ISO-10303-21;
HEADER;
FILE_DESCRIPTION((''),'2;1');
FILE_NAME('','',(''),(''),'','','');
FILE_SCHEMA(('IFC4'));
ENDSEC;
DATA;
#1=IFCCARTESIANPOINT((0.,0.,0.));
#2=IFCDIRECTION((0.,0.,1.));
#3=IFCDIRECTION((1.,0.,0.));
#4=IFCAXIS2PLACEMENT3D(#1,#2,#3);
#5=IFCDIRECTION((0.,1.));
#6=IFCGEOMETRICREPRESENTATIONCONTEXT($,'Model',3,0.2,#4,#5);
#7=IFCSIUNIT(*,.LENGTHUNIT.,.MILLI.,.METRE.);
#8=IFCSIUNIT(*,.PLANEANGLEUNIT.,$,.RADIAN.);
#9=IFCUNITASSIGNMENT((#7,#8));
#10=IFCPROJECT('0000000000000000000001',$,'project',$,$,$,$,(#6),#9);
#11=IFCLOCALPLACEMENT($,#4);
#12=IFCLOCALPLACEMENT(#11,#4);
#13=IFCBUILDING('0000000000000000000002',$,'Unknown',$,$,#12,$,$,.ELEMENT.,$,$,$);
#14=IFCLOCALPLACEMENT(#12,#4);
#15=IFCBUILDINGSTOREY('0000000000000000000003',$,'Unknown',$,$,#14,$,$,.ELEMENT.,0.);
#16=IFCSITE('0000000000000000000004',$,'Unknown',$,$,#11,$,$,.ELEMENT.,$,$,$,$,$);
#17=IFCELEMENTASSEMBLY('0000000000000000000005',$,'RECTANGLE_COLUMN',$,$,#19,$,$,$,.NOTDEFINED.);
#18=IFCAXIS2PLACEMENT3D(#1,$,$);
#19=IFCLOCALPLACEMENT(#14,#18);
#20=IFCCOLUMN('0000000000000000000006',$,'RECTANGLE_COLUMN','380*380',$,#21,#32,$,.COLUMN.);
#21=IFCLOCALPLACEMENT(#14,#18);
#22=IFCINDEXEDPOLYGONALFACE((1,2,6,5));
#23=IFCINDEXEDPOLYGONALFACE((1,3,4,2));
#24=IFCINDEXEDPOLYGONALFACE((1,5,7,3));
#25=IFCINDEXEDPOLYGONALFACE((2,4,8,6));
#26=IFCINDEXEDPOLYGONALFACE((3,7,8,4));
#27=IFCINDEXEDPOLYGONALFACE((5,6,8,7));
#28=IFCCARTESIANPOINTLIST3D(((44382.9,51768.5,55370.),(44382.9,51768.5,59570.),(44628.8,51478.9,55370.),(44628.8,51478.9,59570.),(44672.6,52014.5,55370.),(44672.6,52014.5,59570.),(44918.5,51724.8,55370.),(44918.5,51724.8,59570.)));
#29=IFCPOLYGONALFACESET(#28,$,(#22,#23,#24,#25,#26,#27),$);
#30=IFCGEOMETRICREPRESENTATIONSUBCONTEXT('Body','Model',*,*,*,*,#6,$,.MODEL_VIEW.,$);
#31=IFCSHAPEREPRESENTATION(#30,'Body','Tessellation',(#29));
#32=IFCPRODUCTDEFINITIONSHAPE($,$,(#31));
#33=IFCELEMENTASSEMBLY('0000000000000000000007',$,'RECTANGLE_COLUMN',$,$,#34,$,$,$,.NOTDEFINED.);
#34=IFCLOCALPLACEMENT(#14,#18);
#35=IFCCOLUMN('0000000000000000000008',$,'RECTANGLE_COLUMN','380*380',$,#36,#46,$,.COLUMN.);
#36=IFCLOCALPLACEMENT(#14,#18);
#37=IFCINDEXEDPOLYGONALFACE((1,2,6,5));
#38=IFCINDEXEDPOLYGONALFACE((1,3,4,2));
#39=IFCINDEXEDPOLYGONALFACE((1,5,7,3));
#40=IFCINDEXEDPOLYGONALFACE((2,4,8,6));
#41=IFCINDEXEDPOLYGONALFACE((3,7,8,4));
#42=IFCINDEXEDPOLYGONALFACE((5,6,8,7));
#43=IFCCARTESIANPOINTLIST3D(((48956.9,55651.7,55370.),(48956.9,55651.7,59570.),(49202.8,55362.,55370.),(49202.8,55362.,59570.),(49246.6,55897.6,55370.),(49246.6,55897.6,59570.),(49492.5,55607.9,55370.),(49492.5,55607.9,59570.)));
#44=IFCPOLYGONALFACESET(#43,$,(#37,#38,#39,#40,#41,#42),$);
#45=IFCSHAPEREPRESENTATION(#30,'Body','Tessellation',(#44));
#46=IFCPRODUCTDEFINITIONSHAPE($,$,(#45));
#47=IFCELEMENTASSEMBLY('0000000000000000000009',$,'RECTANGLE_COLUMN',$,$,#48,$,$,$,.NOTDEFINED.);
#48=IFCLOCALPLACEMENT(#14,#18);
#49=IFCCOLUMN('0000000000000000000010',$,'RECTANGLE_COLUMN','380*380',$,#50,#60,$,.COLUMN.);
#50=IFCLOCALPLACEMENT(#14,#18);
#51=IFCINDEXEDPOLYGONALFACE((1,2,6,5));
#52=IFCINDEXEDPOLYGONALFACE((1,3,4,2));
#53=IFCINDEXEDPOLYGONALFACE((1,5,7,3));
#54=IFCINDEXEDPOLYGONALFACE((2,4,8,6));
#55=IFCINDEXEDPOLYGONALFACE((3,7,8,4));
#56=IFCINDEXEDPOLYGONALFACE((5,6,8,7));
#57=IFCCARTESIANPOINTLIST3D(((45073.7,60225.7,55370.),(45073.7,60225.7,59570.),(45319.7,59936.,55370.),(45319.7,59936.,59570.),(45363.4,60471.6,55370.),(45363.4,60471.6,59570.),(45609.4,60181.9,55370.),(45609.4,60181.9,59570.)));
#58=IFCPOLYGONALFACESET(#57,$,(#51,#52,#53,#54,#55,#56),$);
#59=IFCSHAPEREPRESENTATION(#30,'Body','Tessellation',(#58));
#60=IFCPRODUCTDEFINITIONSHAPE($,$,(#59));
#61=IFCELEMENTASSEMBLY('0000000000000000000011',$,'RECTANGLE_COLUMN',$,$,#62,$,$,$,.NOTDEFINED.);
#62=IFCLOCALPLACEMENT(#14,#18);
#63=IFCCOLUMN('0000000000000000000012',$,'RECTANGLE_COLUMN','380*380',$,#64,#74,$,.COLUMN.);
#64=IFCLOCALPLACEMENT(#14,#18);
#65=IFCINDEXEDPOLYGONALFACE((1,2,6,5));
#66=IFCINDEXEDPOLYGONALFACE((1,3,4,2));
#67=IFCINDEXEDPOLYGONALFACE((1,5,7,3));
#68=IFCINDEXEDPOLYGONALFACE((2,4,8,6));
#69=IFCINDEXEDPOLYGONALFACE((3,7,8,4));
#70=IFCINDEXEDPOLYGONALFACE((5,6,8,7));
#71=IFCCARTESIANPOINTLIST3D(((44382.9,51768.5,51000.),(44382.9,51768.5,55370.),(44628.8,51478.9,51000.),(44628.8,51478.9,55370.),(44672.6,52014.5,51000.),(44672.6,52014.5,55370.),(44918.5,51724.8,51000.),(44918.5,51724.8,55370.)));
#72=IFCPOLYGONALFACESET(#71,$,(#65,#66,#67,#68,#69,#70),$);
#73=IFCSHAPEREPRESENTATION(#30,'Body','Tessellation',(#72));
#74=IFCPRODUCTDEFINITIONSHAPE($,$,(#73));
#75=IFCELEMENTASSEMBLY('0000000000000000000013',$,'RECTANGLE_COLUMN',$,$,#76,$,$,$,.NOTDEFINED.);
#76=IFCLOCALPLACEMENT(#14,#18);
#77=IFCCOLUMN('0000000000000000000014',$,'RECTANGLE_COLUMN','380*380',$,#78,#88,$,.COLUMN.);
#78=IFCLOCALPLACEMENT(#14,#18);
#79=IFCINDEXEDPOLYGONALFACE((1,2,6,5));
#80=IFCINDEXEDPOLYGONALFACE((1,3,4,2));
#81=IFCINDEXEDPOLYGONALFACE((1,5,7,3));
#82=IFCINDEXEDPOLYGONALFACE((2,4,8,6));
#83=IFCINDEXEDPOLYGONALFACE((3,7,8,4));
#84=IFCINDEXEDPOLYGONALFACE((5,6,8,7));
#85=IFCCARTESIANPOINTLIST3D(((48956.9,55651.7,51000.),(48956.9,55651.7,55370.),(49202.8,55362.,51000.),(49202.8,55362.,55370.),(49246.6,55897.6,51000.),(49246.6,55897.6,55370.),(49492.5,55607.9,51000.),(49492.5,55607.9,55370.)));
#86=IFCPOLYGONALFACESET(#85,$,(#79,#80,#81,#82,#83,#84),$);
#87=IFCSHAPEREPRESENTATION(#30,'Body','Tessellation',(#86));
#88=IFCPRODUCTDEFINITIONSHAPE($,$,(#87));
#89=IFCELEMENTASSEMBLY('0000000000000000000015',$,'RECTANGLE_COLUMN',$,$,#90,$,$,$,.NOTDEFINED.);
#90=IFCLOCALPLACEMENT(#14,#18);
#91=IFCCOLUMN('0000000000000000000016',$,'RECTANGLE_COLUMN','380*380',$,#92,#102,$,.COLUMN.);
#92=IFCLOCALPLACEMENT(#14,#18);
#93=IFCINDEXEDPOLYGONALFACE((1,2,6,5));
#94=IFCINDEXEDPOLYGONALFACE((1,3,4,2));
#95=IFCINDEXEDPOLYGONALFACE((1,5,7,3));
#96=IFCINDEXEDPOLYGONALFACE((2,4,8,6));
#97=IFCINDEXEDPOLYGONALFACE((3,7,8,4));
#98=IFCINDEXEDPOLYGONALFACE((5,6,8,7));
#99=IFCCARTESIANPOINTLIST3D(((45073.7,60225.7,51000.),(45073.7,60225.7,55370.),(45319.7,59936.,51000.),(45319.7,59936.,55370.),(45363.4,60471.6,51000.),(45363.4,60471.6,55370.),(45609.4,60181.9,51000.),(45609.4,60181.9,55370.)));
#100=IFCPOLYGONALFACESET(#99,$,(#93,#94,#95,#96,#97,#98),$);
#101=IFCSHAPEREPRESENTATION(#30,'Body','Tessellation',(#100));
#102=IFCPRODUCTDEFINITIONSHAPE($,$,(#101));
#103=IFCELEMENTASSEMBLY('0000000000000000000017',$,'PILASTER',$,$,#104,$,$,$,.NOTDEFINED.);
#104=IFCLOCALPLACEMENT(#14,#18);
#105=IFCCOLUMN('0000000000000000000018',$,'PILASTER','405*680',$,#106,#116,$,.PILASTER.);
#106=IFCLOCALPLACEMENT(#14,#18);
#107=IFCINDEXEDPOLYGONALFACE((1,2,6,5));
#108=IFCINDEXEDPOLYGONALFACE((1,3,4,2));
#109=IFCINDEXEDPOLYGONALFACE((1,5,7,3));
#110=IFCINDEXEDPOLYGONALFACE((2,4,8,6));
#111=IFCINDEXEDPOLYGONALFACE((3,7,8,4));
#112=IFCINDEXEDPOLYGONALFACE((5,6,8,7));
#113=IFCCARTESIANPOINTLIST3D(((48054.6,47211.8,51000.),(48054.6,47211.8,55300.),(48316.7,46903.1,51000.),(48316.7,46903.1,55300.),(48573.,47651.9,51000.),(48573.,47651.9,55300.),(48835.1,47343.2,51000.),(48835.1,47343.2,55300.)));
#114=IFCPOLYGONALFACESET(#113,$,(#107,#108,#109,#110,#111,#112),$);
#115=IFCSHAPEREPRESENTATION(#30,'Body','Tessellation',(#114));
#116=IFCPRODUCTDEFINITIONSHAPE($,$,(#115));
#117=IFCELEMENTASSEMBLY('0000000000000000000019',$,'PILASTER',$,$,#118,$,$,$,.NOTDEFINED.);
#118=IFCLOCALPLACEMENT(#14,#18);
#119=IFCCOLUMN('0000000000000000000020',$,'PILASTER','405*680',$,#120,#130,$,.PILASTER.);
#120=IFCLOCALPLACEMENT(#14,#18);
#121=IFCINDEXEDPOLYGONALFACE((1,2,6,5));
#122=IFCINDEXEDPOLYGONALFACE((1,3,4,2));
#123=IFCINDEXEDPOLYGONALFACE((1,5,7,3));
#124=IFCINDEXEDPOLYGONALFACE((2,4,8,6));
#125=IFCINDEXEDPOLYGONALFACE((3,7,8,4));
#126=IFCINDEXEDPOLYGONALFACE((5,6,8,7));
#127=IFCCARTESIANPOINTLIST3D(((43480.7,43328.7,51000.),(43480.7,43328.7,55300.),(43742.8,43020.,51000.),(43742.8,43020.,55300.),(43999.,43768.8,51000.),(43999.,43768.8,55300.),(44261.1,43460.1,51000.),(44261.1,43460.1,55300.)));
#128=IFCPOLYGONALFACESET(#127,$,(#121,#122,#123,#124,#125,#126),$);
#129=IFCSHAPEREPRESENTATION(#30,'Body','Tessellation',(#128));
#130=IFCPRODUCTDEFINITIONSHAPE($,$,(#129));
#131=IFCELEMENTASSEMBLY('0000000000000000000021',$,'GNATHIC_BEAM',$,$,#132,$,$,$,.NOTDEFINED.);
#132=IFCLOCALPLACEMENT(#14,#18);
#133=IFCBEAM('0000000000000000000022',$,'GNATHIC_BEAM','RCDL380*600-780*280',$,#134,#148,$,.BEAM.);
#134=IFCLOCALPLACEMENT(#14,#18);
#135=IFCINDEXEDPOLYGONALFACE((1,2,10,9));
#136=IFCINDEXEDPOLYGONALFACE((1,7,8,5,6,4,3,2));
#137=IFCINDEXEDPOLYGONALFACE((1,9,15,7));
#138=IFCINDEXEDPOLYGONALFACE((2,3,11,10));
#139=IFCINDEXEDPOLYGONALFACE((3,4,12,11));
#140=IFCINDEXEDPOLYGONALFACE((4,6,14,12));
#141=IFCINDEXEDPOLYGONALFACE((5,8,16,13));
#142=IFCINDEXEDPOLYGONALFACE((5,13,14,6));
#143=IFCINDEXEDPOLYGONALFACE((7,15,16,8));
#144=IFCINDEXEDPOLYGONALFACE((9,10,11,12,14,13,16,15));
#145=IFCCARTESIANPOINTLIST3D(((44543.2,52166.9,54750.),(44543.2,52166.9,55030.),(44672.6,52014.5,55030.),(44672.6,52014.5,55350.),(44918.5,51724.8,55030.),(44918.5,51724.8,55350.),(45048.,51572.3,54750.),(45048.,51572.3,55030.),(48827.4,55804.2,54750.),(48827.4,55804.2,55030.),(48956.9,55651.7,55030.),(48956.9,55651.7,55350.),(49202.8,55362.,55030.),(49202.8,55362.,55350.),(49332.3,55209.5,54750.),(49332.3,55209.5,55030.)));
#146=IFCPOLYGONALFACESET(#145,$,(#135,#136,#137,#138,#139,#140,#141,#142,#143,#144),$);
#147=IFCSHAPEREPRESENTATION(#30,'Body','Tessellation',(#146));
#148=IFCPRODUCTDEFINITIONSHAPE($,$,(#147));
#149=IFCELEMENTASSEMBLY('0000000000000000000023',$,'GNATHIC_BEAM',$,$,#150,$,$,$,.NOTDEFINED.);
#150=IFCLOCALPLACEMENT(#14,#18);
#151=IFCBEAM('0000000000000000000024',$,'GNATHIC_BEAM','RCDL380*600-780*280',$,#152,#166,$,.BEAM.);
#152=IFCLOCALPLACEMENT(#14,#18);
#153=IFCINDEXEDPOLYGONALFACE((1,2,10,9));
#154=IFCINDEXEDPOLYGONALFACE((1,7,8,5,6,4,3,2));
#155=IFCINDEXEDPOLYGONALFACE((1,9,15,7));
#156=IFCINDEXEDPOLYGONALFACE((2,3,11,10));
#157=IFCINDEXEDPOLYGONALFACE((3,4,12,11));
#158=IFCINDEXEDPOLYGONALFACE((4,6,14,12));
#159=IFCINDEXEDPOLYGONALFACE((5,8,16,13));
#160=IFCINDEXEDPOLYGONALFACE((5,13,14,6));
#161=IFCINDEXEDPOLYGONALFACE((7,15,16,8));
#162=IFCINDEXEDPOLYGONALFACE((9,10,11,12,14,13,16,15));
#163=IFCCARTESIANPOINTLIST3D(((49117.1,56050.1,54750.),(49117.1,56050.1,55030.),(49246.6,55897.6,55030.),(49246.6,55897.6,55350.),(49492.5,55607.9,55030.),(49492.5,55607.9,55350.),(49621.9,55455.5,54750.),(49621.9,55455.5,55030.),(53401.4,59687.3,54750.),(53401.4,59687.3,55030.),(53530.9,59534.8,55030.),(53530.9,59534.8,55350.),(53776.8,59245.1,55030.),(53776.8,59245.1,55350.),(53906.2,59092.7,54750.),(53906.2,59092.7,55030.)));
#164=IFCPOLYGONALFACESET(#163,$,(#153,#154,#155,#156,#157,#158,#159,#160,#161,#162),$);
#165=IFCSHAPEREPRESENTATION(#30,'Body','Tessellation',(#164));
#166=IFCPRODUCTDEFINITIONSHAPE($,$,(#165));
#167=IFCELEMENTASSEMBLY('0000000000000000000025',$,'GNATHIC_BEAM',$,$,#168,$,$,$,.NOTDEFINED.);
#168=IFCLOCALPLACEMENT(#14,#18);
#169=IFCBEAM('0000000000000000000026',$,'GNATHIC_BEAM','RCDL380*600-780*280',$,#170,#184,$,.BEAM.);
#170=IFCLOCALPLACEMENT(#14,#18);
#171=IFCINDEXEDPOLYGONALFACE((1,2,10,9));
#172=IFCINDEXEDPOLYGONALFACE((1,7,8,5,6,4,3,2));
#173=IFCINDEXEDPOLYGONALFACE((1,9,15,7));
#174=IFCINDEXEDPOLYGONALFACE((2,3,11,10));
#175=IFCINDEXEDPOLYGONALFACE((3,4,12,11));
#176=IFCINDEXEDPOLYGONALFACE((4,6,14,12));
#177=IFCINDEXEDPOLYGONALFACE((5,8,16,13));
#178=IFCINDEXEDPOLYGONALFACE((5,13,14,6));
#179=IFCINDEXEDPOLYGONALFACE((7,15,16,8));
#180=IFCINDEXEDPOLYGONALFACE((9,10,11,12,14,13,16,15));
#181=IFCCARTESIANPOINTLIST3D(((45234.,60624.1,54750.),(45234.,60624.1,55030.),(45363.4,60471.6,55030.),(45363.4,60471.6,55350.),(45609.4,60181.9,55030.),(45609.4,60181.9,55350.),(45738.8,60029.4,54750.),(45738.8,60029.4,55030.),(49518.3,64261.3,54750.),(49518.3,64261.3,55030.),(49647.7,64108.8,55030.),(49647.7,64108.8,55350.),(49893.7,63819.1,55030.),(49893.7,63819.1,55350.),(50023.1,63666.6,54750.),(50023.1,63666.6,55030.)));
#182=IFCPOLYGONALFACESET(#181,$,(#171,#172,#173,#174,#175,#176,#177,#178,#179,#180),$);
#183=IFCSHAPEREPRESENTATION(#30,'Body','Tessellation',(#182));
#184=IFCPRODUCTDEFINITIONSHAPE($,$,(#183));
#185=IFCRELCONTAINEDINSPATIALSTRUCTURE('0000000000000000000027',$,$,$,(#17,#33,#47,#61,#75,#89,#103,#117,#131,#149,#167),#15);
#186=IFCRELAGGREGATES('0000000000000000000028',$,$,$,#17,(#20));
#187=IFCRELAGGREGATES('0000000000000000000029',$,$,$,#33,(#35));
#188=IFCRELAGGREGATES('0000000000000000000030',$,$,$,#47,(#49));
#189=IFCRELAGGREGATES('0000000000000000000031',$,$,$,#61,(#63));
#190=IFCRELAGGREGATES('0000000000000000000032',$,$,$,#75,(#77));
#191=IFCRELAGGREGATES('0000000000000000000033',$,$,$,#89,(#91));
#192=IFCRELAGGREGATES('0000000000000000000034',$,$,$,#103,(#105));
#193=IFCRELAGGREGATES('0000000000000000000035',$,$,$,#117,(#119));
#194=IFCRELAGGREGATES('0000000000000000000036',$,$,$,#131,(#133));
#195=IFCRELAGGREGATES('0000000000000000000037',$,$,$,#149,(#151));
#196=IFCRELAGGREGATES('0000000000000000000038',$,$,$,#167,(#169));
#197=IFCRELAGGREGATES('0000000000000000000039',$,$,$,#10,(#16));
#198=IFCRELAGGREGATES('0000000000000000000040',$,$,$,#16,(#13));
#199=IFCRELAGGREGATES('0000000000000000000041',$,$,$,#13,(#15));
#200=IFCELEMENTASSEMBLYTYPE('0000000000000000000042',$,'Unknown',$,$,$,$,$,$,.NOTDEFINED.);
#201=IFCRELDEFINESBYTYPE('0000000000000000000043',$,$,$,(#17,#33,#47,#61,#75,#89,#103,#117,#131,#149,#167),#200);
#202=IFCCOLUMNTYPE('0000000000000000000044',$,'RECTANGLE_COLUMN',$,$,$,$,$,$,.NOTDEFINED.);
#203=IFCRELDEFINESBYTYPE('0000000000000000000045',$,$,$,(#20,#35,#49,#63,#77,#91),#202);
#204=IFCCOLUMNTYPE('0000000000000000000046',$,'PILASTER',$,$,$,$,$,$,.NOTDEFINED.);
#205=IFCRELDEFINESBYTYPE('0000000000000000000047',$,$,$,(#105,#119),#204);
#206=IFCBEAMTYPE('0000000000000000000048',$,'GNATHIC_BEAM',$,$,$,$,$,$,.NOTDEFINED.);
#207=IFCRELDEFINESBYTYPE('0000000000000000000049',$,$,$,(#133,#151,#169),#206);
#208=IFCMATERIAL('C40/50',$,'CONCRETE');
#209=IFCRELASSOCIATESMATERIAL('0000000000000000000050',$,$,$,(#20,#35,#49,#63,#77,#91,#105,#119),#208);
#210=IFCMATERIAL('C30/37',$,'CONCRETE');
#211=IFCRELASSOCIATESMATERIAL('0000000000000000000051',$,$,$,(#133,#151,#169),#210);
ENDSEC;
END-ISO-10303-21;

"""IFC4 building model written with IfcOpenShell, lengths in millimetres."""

from ifc_helpers import new_model, si_unit, direction, frame, origin_with_axes, origin_2d_with_axis, place, context, subcontext, project, spatial, polyline, rectangle, outline, extrude, material, material_profile, profile_set, profile_usage, type_object, element, aggregate, save


model = new_model("IFC4")

# Units and contexts
model_context = context("Model", 3, precision=0.2, world=origin_with_axes(), true_north=direction((0.0, 1.0)))
body_context = subcontext(model_context, "Body", "Model", "MODEL_VIEW")
ifc_project = project(units=[si_unit("LENGTHUNIT", "METRE", prefix="MILLI"), si_unit("PLANEANGLEUNIT", "RADIAN")], contexts=[model_context])

# Site, building, storey
site_placement = place(None, origin_with_axes())
site = spatial("IfcSite", under=ifc_project, at=site_placement, Name="Unknown", CompositionType="ELEMENT")
building_placement = place(site_placement, origin_with_axes())
building = spatial("IfcBuilding", under=site, at=building_placement, Name="Unknown", CompositionType="ELEMENT")
storey_placement = place(building_placement, origin_with_axes())
storey = spatial("IfcBuildingStorey", under=building, at=storey_placement, Name="Unknown", CompositionType="ELEMENT", Elevation=0.0)

# Shared definitions
element_assembly_type = type_object("IfcElementAssemblyType", Name="Unknown", PredefinedType="NOTDEFINED")
ifc_material_1 = material(Name="C40/50", Category="CONCRETE")

# Element assemblies, columns
ifc_material_profile_1 = material_profile(ifc_material_1, rectangle(XDim=380.0, YDim=380.0, at=origin_2d_with_axis()), Name="380*380")
ifc_profile_set_1 = profile_set([ifc_material_profile_1])
ifc_profile_usage_1 = profile_usage(ifc_profile_set_1, cardinal=5)
column_type_1 = type_object("IfcColumnType", Name="RECTANGLE_COLUMN")
assembly_1_placement = place(storey_placement, frame((44650.7, 51746.7, 55370.0), z_axis=(-0.762329, -0.64719, 0.0), x_axis=(0.0, 0.0, 1.0)))
assembly_1 = element("IfcElementAssembly", 1, at=assembly_1_placement, inside=storey, type_object=element_assembly_type, Name="RECTANGLE_COLUMN", PredefinedType="NOTDEFINED")
column_1_placement = place(assembly_1_placement, origin_with_axes())
column_1 = element("IfcColumn", 2, at=column_1_placement, type_object=column_type_1, material=ifc_profile_usage_1, Name="RECTANGLE_COLUMN", Description="380*380", PredefinedType="COLUMN", context=body_context, shape_type="SolidModel", body=[
    extrude(rectangle(XDim=380.0, YDim=380.0, at=origin_2d_with_axis()), frame((0.0, 0.0, 0.0), z_axis=(-1.0, 0.0, 0.0), x_axis=(0.0, 0.0, 1.0)), (0.0, 0.0, -1.0), 4200.0),
])
aggregate(assembly_1, [column_1])
assembly_2_placement = place(storey_placement, frame((49224.7, 55629.8, 55370.0), z_axis=(-0.762329, -0.64719, 0.0), x_axis=(0.0, 0.0, 1.0)))
assembly_2 = element("IfcElementAssembly", 3, at=assembly_2_placement, inside=storey, type_object=element_assembly_type, Name="RECTANGLE_COLUMN", PredefinedType="NOTDEFINED")
column_2_placement = place(assembly_2_placement, origin_with_axes())
column_2 = element("IfcColumn", 4, at=column_2_placement, type_object=column_type_1, material=ifc_profile_usage_1, Name="RECTANGLE_COLUMN", Description="380*380", PredefinedType="COLUMN", context=body_context, shape_type="SolidModel", body=[
    extrude(rectangle(XDim=380.0, YDim=380.0, at=origin_2d_with_axis()), frame((0.0, 0.0, 0.0), z_axis=(-1.0, 0.0, 0.0), x_axis=(0.0, 0.0, 1.0)), (0.0, 0.0, -1.0), 4200.0),
])
aggregate(assembly_2, [column_2])
assembly_3_placement = place(storey_placement, frame((45341.6, 60203.8, 55370.0), z_axis=(-0.762329, -0.64719, 0.0), x_axis=(0.0, 0.0, 1.0)))
assembly_3 = element("IfcElementAssembly", 5, at=assembly_3_placement, inside=storey, type_object=element_assembly_type, Name="RECTANGLE_COLUMN", PredefinedType="NOTDEFINED")
column_3_placement = place(assembly_3_placement, origin_with_axes())
column_3 = element("IfcColumn", 6, at=column_3_placement, type_object=column_type_1, material=ifc_profile_usage_1, Name="RECTANGLE_COLUMN", Description="380*380", PredefinedType="COLUMN", context=body_context, shape_type="SolidModel", body=[
    extrude(rectangle(XDim=380.0, YDim=380.0, at=origin_2d_with_axis()), frame((0.0, 0.0, 0.0), z_axis=(-1.0, 0.0, 0.0), x_axis=(0.0, 0.0, 1.0)), (0.0, 0.0, -1.0), 4200.0),
])
aggregate(assembly_3, [column_3])
assembly_4_placement = place(storey_placement, frame((44650.7, 51746.7, 51000.0), z_axis=(-0.762329, -0.64719, 0.0), x_axis=(0.0, 0.0, 1.0)))
assembly_4 = element("IfcElementAssembly", 7, at=assembly_4_placement, inside=storey, type_object=element_assembly_type, Name="RECTANGLE_COLUMN", PredefinedType="NOTDEFINED")
column_4_placement = place(assembly_4_placement, origin_with_axes())
column_4 = element("IfcColumn", 8, at=column_4_placement, type_object=column_type_1, material=ifc_profile_usage_1, Name="RECTANGLE_COLUMN", Description="380*380", PredefinedType="COLUMN", context=body_context, shape_type="SolidModel", body=[
    extrude(rectangle(XDim=380.0, YDim=380.0, at=origin_2d_with_axis()), frame((0.0, 0.0, 0.0), z_axis=(-1.0, 0.0, 0.0), x_axis=(0.0, 0.0, 1.0)), (0.0, 0.0, -1.0), 4370.0),
])
aggregate(assembly_4, [column_4])
assembly_5_placement = place(storey_placement, frame((49224.7, 55629.8, 51000.0), z_axis=(-0.762329, -0.64719, 0.0), x_axis=(0.0, 0.0, 1.0)))
assembly_5 = element("IfcElementAssembly", 9, at=assembly_5_placement, inside=storey, type_object=element_assembly_type, Name="RECTANGLE_COLUMN", PredefinedType="NOTDEFINED")
column_5_placement = place(assembly_5_placement, origin_with_axes())
column_5 = element("IfcColumn", 10, at=column_5_placement, type_object=column_type_1, material=ifc_profile_usage_1, Name="RECTANGLE_COLUMN", Description="380*380", PredefinedType="COLUMN", context=body_context, shape_type="SolidModel", body=[
    extrude(rectangle(XDim=380.0, YDim=380.0, at=origin_2d_with_axis()), frame((0.0, 0.0, 0.0), z_axis=(-1.0, 0.0, 0.0), x_axis=(0.0, 0.0, 1.0)), (0.0, 0.0, -1.0), 4370.0),
])
aggregate(assembly_5, [column_5])
assembly_6_placement = place(storey_placement, frame((45341.6, 60203.8, 51000.0), z_axis=(-0.762329, -0.64719, 0.0), x_axis=(0.0, 0.0, 1.0)))
assembly_6 = element("IfcElementAssembly", 11, at=assembly_6_placement, inside=storey, type_object=element_assembly_type, Name="RECTANGLE_COLUMN", PredefinedType="NOTDEFINED")
column_6_placement = place(assembly_6_placement, origin_with_axes())
column_6 = element("IfcColumn", 12, at=column_6_placement, type_object=column_type_1, material=ifc_profile_usage_1, Name="RECTANGLE_COLUMN", Description="380*380", PredefinedType="COLUMN", context=body_context, shape_type="SolidModel", body=[
    extrude(rectangle(XDim=380.0, YDim=380.0, at=origin_2d_with_axis()), frame((0.0, 0.0, 0.0), z_axis=(-1.0, 0.0, 0.0), x_axis=(0.0, 0.0, 1.0)), (0.0, 0.0, -1.0), 4370.0),
])
aggregate(assembly_6, [column_6])
assembly_7_placement = place(storey_placement, frame((48444.9, 47277.5, 51000.0), z_axis=(-0.762329, -0.64719, 0.0), x_axis=(0.0, 0.0, 1.0)))
assembly_7 = element("IfcElementAssembly", 13, at=assembly_7_placement, inside=storey, type_object=element_assembly_type, Name="PILASTER", PredefinedType="NOTDEFINED")
ifc_material_profile_2 = material_profile(ifc_material_1, rectangle(XDim=680.0, YDim=405.0, at=origin_2d_with_axis()), Name="405*680")
ifc_profile_set_2 = profile_set([ifc_material_profile_2])
ifc_profile_usage_2 = profile_usage(ifc_profile_set_2, cardinal=6)
column_type_2 = type_object("IfcColumnType", Name="PILASTER")
column_7_placement = place(assembly_7_placement, origin_with_axes())
column_7 = element("IfcColumn", 14, at=column_7_placement, type_object=column_type_2, material=ifc_profile_usage_2, Name="PILASTER", Description="405*680", PredefinedType="PILASTER", context=body_context, shape_type="SolidModel", body=[
    extrude(rectangle(XDim=680.0, YDim=405.0, at=origin_2d_with_axis()), frame((0.0, 0.0, 0.0), z_axis=(-1.0, 0.0, 0.0), x_axis=(0.0, 0.0, 1.0)), (0.0, 0.0, -1.0), 4300.0),
])
aggregate(assembly_7, [column_7])
assembly_8_placement = place(storey_placement, frame((43870.9, 43394.4, 51000.0), z_axis=(-0.762329, -0.64719, 0.0), x_axis=(0.0, 0.0, 1.0)))
assembly_8 = element("IfcElementAssembly", 15, at=assembly_8_placement, inside=storey, type_object=element_assembly_type, Name="PILASTER", PredefinedType="NOTDEFINED")
column_8_placement = place(assembly_8_placement, origin_with_axes())
column_8 = element("IfcColumn", 16, at=column_8_placement, type_object=column_type_2, material=ifc_profile_usage_2, Name="PILASTER", Description="405*680", PredefinedType="PILASTER", context=body_context, shape_type="SolidModel", body=[
    extrude(rectangle(XDim=680.0, YDim=405.0, at=origin_2d_with_axis()), frame((0.0, 0.0, 0.0), z_axis=(-1.0, 0.0, 0.0), x_axis=(0.0, 0.0, 1.0)), (0.0, 0.0, -1.0), 4300.0),
])
aggregate(assembly_8, [column_8])

# Element assemblies, beams
assembly_9_placement = place(storey_placement, frame((44795.6, 51869.6, 55050.0), z_axis=(0.64719, -0.762329, 0.0), x_axis=(0.762329, 0.64719, 0.0)))
assembly_9 = element("IfcElementAssembly", 17, at=assembly_9_placement, inside=storey, type_object=element_assembly_type, Name="GNATHIC_BEAM", PredefinedType="NOTDEFINED")
ifc_material_2 = material(Name="C30/37", Category="CONCRETE")
ifc_material_profile_3 = material_profile(ifc_material_2, outline(polyline([(-390.0, -300.0), (390.0, -300.0), (390.0, -20.0), (190.0, -20.0), (190.0, 300.0), (-190.0, 300.0), (-190.0, -20.0), (-390.0, -20.0), (-390.0, -300.0)])), Name="RCDL380*600-780*280")
ifc_profile_set_3 = profile_set([ifc_material_profile_3])
ifc_profile_usage_3 = profile_usage(ifc_profile_set_3, cardinal=2)
beam_type_1 = type_object("IfcBeamType", Name="GNATHIC_BEAM")
beam_1_placement = place(assembly_9_placement, origin_with_axes())
beam_1 = element("IfcBeam", 18, at=beam_1_placement, type_object=beam_type_1, material=ifc_profile_usage_3, Name="GNATHIC_BEAM", Description="RCDL380*600-780*280", PredefinedType="BEAM", context=body_context, shape_type="SolidModel", body=[
    extrude(outline(polyline([(-390.0, -300.0), (390.0, -300.0), (390.0, -20.0), (190.0, -20.0), (190.0, 300.0), (-190.0, 300.0), (-190.0, -20.0), (-390.0, -20.0), (-390.0, -300.0)])), frame((0.0, 0.0, 0.0), z_axis=(-1.0, 0.0, 0.0), x_axis=(0.0, 0.0, 1.0)), (0.0, 0.0, -1.0), 5620.0),
])
aggregate(assembly_9, [beam_1])
assembly_10_placement = place(storey_placement, frame((49369.5, 55752.8, 55050.0), z_axis=(0.64719, -0.762329, 0.0), x_axis=(0.762329, 0.64719, 0.0)))
assembly_10 = element("IfcElementAssembly", 19, at=assembly_10_placement, inside=storey, type_object=element_assembly_type, Name="GNATHIC_BEAM", PredefinedType="NOTDEFINED")
beam_2_placement = place(assembly_10_placement, origin_with_axes())
beam_2 = element("IfcBeam", 20, at=beam_2_placement, type_object=beam_type_1, material=ifc_profile_usage_3, Name="GNATHIC_BEAM", Description="RCDL380*600-780*280", PredefinedType="BEAM", context=body_context, shape_type="SolidModel", body=[
    extrude(outline(polyline([(-390.0, -300.0), (390.0, -300.0), (390.0, -20.0), (190.0, -20.0), (190.0, 300.0), (-190.0, 300.0), (-190.0, -20.0), (-390.0, -20.0), (-390.0, -300.0)])), frame((0.0, 0.0, 0.0), z_axis=(-1.0, 0.0, 0.0), x_axis=(0.0, 0.0, 1.0)), (0.0, 0.0, -1.0), 5620.0),
])
aggregate(assembly_10, [beam_2])
assembly_11_placement = place(storey_placement, frame((45486.4, 60326.7, 55050.0), z_axis=(0.64719, -0.762329, 0.0), x_axis=(0.762329, 0.64719, 0.0)))
assembly_11 = element("IfcElementAssembly", 21, at=assembly_11_placement, inside=storey, type_object=element_assembly_type, Name="GNATHIC_BEAM", PredefinedType="NOTDEFINED")
beam_3_placement = place(assembly_11_placement, origin_with_axes())
beam_3 = element("IfcBeam", 22, at=beam_3_placement, type_object=beam_type_1, material=ifc_profile_usage_3, Name="GNATHIC_BEAM", Description="RCDL380*600-780*280", PredefinedType="BEAM", context=body_context, shape_type="SolidModel", body=[
    extrude(outline(polyline([(-390.0, -300.0), (390.0, -300.0), (390.0, -20.0), (190.0, -20.0), (190.0, 300.0), (-190.0, 300.0), (-190.0, -20.0), (-390.0, -20.0), (-390.0, -300.0)])), frame((0.0, 0.0, 0.0), z_axis=(-1.0, 0.0, 0.0), x_axis=(0.0, 0.0, 1.0)), (0.0, 0.0, -1.0), 5620.0),
])
aggregate(assembly_11, [beam_3])

save(model, "model.ifc")
